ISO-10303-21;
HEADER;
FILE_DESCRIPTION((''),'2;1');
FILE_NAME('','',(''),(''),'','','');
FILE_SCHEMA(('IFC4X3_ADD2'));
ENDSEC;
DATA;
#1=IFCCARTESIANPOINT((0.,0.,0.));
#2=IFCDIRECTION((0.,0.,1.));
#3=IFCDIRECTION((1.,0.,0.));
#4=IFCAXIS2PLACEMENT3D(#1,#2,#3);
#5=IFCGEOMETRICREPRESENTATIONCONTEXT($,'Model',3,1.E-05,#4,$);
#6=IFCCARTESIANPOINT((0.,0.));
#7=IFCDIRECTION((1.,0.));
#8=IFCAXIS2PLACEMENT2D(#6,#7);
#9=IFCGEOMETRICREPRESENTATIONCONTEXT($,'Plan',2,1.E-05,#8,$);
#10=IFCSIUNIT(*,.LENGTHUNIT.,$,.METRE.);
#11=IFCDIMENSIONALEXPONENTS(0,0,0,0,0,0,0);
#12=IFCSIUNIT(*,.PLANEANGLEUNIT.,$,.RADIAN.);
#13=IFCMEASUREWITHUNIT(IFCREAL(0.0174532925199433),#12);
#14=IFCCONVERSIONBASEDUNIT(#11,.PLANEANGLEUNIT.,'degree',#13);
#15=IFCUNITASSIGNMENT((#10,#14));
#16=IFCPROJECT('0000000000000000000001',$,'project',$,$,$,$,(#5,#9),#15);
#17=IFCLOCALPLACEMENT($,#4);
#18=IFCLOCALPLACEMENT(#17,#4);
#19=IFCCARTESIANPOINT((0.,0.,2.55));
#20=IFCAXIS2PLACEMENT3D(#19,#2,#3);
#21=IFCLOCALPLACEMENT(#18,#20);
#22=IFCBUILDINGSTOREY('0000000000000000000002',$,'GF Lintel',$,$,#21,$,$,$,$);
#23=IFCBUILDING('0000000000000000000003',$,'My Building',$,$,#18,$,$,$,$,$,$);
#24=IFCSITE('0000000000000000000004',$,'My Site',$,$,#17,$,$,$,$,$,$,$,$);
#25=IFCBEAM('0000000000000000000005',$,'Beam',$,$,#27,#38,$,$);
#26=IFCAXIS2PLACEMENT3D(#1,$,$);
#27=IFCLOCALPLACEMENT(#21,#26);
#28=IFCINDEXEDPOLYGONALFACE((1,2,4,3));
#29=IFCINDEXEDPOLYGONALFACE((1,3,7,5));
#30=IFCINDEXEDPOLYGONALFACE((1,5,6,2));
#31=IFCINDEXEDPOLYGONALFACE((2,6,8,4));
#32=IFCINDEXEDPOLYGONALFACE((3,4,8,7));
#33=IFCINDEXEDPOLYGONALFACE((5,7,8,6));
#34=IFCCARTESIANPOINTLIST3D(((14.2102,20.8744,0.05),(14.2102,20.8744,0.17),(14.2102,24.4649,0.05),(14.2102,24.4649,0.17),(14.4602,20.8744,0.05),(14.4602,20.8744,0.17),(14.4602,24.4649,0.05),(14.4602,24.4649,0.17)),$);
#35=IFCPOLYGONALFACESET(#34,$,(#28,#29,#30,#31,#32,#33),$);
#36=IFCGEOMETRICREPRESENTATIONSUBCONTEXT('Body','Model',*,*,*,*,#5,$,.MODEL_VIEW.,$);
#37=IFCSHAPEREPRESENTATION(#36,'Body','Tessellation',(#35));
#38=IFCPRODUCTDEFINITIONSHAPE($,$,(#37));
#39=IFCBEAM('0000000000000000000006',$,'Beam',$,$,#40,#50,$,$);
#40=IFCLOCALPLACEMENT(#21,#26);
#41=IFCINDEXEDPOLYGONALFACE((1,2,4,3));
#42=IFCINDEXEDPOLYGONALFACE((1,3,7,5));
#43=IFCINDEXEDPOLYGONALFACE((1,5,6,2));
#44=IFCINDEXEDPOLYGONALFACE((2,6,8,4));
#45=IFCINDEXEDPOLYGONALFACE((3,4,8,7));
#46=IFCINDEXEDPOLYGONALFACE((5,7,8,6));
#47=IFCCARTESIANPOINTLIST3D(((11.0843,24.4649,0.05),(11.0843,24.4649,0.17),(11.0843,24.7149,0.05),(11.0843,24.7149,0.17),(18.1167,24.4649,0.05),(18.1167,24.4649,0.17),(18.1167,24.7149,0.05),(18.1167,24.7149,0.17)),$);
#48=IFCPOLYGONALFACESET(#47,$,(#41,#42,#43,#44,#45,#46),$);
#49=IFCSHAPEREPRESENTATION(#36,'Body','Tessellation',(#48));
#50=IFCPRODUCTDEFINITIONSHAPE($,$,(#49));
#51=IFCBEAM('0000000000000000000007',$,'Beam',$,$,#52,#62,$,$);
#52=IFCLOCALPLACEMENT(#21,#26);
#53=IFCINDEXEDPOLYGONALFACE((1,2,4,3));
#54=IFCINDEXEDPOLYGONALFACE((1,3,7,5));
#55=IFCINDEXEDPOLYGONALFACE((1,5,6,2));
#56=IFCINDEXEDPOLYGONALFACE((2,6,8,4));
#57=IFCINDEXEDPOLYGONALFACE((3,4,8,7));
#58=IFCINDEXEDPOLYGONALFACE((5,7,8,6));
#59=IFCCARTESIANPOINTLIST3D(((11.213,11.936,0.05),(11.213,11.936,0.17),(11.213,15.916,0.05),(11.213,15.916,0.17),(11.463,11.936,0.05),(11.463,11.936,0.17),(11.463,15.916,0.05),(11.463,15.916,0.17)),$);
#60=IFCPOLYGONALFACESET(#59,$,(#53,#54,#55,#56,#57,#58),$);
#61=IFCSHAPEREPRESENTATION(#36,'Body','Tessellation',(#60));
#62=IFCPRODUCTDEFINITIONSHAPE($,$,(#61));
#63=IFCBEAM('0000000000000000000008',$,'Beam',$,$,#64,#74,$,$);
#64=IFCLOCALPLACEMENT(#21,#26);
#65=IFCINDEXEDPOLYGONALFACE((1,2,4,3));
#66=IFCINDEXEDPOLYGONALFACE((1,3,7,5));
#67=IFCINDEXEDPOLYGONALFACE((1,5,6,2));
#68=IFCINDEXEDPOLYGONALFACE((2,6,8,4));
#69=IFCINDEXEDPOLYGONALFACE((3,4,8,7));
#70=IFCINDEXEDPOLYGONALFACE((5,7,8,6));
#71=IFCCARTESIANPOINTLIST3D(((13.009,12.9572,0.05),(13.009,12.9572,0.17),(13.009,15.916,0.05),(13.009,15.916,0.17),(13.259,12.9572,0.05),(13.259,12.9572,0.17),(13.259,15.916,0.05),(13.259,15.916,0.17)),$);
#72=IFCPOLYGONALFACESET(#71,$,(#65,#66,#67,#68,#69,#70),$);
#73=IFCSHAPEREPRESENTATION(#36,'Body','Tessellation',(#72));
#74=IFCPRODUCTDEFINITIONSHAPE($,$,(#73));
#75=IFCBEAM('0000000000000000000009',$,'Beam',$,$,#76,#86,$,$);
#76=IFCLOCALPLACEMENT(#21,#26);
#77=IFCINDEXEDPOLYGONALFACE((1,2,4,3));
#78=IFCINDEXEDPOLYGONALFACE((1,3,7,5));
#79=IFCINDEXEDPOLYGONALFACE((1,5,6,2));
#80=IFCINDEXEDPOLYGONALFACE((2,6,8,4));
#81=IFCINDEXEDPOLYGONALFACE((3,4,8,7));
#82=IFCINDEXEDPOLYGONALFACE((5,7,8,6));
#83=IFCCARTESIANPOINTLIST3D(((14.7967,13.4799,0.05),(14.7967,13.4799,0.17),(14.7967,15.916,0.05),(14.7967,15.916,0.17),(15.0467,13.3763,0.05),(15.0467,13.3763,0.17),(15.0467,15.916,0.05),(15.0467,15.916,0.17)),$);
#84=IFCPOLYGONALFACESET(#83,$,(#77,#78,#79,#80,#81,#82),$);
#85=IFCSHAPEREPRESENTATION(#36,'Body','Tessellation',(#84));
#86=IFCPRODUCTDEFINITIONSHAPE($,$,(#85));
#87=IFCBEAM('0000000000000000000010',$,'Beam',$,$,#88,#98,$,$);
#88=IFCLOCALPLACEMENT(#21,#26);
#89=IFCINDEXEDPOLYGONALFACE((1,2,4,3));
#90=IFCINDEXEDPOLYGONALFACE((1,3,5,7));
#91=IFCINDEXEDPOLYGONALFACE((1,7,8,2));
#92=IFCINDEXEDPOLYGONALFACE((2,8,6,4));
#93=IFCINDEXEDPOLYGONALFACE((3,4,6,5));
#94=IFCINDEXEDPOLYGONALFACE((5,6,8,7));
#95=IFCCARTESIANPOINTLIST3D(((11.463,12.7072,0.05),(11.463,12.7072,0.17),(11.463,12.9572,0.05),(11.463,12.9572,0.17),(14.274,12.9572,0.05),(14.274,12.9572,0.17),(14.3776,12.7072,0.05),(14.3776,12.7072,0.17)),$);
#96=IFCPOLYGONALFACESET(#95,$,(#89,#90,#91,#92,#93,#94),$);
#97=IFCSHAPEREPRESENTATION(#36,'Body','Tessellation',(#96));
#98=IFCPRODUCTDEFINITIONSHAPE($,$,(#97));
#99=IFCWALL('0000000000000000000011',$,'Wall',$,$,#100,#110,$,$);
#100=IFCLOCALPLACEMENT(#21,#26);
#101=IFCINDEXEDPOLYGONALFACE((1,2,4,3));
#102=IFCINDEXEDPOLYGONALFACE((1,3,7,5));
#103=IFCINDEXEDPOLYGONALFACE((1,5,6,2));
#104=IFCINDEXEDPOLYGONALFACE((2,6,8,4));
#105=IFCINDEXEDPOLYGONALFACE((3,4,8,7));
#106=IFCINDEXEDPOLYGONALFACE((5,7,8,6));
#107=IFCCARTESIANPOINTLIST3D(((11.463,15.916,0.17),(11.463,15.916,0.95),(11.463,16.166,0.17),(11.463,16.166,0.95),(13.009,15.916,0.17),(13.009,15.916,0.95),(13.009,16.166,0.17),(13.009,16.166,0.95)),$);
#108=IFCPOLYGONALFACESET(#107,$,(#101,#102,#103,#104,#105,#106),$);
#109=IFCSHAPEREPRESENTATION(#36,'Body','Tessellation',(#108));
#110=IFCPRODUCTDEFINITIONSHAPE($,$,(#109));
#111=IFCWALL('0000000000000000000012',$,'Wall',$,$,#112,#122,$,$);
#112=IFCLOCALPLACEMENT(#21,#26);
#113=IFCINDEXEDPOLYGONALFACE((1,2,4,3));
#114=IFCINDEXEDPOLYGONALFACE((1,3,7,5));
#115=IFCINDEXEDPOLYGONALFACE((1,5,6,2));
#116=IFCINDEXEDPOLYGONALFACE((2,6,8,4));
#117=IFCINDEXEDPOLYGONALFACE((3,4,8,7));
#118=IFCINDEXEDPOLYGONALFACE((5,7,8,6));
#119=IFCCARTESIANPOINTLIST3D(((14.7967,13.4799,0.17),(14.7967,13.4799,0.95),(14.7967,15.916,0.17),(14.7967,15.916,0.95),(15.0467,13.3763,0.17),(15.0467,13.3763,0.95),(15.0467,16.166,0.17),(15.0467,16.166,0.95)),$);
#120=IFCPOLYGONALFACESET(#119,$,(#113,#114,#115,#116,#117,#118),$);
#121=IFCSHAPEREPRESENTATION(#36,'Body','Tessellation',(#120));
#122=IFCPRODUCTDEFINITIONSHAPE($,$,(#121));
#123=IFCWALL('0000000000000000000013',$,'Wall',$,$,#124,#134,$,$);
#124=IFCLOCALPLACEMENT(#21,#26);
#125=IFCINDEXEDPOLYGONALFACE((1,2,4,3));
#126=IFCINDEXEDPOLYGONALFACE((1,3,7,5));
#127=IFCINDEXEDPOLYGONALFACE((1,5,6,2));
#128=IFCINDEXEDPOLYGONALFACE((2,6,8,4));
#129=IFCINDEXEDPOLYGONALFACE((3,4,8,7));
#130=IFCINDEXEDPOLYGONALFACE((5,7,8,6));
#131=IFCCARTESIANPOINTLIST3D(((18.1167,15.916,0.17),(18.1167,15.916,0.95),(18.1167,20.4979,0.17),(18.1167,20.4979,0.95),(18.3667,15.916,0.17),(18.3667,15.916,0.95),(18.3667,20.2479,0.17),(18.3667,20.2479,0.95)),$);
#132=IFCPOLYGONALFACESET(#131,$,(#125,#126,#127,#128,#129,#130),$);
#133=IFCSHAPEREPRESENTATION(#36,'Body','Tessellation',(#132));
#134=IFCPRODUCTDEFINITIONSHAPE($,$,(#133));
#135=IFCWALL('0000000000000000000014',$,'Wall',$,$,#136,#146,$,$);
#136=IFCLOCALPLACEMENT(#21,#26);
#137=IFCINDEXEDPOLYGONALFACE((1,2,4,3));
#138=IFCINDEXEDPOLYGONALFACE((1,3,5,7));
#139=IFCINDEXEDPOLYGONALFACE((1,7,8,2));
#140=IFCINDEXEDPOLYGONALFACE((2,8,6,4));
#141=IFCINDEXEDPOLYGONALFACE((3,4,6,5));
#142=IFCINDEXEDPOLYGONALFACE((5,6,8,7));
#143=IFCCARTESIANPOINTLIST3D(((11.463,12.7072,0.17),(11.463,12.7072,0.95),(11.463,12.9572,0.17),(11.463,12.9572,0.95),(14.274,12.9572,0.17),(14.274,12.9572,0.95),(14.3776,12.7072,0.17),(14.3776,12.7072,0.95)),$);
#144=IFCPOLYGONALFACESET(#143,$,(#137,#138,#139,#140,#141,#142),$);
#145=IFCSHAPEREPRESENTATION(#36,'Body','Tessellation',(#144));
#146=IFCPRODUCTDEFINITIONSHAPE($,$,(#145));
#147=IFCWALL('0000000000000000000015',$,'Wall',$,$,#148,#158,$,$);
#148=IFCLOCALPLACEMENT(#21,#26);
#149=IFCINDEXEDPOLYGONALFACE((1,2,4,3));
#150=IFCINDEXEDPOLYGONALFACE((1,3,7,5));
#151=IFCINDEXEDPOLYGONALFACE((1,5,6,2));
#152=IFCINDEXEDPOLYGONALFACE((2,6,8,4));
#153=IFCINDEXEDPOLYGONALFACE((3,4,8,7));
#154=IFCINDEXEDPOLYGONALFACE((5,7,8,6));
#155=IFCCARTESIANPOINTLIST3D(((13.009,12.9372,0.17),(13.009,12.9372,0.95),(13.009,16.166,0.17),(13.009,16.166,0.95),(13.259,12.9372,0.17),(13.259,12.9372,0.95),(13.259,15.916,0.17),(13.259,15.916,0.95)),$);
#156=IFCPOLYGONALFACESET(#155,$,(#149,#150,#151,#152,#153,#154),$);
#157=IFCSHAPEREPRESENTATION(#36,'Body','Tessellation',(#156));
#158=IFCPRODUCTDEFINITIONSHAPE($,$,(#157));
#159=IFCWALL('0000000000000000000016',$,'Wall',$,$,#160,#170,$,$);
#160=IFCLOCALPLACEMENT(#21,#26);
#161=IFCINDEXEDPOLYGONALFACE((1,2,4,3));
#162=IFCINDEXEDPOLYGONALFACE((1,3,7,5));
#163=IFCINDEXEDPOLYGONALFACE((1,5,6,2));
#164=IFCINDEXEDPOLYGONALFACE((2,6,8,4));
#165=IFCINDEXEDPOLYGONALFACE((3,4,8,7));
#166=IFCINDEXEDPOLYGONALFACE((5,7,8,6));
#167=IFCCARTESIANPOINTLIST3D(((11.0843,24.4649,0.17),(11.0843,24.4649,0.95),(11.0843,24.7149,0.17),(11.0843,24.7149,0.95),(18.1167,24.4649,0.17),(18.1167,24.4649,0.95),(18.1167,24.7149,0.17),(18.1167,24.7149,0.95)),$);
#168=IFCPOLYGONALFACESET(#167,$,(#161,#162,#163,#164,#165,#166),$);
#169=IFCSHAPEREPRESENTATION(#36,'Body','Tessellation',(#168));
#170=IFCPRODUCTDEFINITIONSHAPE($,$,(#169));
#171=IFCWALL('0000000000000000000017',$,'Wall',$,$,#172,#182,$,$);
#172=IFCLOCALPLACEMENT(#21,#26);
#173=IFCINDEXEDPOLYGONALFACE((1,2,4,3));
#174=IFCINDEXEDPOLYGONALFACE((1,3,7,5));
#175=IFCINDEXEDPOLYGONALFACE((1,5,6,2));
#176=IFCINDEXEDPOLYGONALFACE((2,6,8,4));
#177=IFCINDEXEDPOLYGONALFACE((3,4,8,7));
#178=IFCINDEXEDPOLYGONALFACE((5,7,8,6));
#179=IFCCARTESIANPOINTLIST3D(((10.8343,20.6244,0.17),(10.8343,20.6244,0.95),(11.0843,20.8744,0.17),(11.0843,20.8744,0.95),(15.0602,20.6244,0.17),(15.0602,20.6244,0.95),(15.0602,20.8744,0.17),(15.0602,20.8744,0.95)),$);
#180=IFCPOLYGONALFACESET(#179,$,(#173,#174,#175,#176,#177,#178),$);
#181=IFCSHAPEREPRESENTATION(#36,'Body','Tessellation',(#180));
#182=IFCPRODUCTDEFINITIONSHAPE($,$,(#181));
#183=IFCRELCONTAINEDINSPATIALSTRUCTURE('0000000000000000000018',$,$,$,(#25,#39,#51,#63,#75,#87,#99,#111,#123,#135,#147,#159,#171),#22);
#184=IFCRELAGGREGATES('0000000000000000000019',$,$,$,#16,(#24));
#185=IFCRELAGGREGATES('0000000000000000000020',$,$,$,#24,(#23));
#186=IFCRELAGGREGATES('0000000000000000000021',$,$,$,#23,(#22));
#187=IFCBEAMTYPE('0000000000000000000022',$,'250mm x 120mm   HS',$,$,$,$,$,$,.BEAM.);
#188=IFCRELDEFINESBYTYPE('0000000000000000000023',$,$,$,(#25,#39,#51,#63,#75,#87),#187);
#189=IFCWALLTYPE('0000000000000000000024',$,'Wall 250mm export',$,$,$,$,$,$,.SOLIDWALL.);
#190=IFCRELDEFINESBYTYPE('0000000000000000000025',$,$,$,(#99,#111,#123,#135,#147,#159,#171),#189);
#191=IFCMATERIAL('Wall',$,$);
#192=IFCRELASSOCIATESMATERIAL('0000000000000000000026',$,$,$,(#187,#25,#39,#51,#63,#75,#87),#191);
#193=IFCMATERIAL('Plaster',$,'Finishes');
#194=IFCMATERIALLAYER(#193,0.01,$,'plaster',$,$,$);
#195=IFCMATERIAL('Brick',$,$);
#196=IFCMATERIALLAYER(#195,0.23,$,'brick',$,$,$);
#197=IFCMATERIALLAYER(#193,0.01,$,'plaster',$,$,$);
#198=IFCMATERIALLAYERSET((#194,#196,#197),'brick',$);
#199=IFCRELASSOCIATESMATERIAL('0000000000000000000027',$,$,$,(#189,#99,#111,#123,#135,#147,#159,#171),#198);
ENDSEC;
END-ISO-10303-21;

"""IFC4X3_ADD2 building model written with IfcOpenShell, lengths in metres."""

from ifc_helpers import new_model, entity, si_unit, converted_unit, frame, origin_with_axes, origin_2d_with_axis, place, context, subcontext, project, spatial, line, indexed_curve, rectangle, outline, extrude, clip, halfspace, material, layer, layer_set, layer_usage, material_profile, profile_set, profile_usage, type_object, element, save


model = new_model("IFC4X3_ADD2")

# Units and contexts
model_context = context("Model", 3, precision=1e-05, world=origin_with_axes())
plan_context = context("Plan", 2, precision=1e-05, world=origin_2d_with_axis())
body_context = subcontext(model_context, "Body", "Model", "MODEL_VIEW")
ifc_project = project(units=[si_unit("LENGTHUNIT", "METRE"), converted_unit("PLANEANGLEUNIT", "degree", entity("IfcReal", 0.0174532925199433), si_unit("PLANEANGLEUNIT", "RADIAN"), dimensions=[0, 0, 0, 0, 0, 0, 0])], contexts=[model_context, plan_context])

# Site, building, storey
site_placement = place(None, origin_with_axes())
site = spatial("IfcSite", under=ifc_project, at=site_placement, Name="My Site")
building_placement = place(site_placement, origin_with_axes())
building = spatial("IfcBuilding", under=site, at=building_placement, Name="My Building")
storey_placement = place(building_placement, frame((0.0, 0.0, 2.55), z_axis=(0.0, 0.0, 1.0), x_axis=(1.0, 0.0, 0.0)))
storey = spatial("IfcBuildingStorey", under=building, at=storey_placement, Name="GF Lintel")

# Beams
ifc_material_1 = material(Name="Wall")
ifc_material_profile = material_profile(ifc_material_1, rectangle(XDim=0.25, YDim=0.12))
ifc_profile_set = profile_set([ifc_material_profile], Name="concrete")
ifc_profile_usage_1 = profile_usage(ifc_profile_set, cardinal=5)
beam_type = type_object("IfcBeamType", Name="250mm x 120mm   HS", PredefinedType="BEAM", material=ifc_profile_set)
beam_1_placement = place(storey_placement, frame((14.3352, 24.4649, 0.11), z_axis=(0.0, -1.0, 0.0), x_axis=(1.0, 0.0, 0.0)))
element("IfcBeam", 1, at=beam_1_placement, inside=storey, type_object=beam_type, material=ifc_profile_usage_1, Name="Beam", context=body_context, shape_type="SweptSolid", body=[
    extrude(rectangle(XDim=0.25, YDim=0.12), origin_with_axes(), (0.0, 0.0, 1.0), 3.5905),
])
ifc_profile_usage_2 = profile_usage(ifc_profile_set, cardinal=5)
beam_2_placement = place(storey_placement, frame((11.0843, 24.5899, 0.11), z_axis=(1.0, 0.0, 0.0), x_axis=(0.0, 1.0, 0.0)))
element("IfcBeam", 2, at=beam_2_placement, inside=storey, type_object=beam_type, material=ifc_profile_usage_2, Name="Beam", context=body_context, shape_type="SweptSolid", body=[
    extrude(rectangle(XDim=0.25, YDim=0.12), origin_with_axes(), (0.0, 0.0, 1.0), 7.0324),
])
ifc_profile_usage_3 = profile_usage(ifc_profile_set, cardinal=5)
beam_3_placement = place(storey_placement, frame((11.338, 15.916, 0.11), z_axis=(0.0, -1.0, 0.0), x_axis=(1.0, 0.0, 0.0)))
element("IfcBeam", 3, at=beam_3_placement, inside=storey, type_object=beam_type, material=ifc_profile_usage_3, Name="Beam", context=body_context, shape_type="SweptSolid", body=[
    extrude(rectangle(XDim=0.25, YDim=0.12), origin_with_axes(), (0.0, 0.0, 1.0), 3.98),
])
ifc_profile_usage_4 = profile_usage(ifc_profile_set, cardinal=5)
beam_4_placement = place(storey_placement, frame((13.134, 15.916, 0.11), z_axis=(0.0, -1.0, 0.0), x_axis=(1.0, 0.0, 0.0)))
element("IfcBeam", 4, at=beam_4_placement, inside=storey, type_object=beam_type, material=ifc_profile_usage_4, Name="Beam", context=body_context, shape_type="SweptSolid", body=[
    extrude(rectangle(XDim=0.25, YDim=0.12), origin_with_axes(), (0.0, 0.0, 1.0), 2.9588),
])
ifc_profile_usage_5 = profile_usage(ifc_profile_set, cardinal=5)
beam_5_placement = place(storey_placement, frame((14.9217, 15.916, 0.11), z_axis=(0.0, -1.0, 0.0), x_axis=(1.0, 0.0, 0.0)))
element("IfcBeam", 5, at=beam_5_placement, inside=storey, type_object=beam_type, material=ifc_profile_usage_5, Name="Beam", context=body_context, shape_type="Clipping", body=[
    clip(extrude(rectangle(XDim=0.25, YDim=0.12), origin_with_axes(), (0.0, 0.0, 1.0), 2.9147), halfspace(frame((0.125, -2.66, 2.5397), z_axis=(-0.382688, 0.0, 0.923878), x_axis=(0.0, 1.0, 0.0)), False)),
])
ifc_profile_usage_6 = profile_usage(ifc_profile_set, cardinal=5)
beam_6_placement = place(storey_placement, frame((11.463, 12.8322, 0.11), z_axis=(1.0, 0.0, 0.0), x_axis=(0.0, 1.0, 0.0)))
element("IfcBeam", 6, at=beam_6_placement, inside=storey, type_object=beam_type, material=ifc_profile_usage_6, Name="Beam", context=body_context, shape_type="Clipping", body=[
    clip(extrude(rectangle(XDim=0.25, YDim=0.12), origin_with_axes(), (0.0, 0.0, 1.0), 3.2896), halfspace(frame((-0.125, -2.66, 2.9146), z_axis=(0.382685, 0.0, 0.923879), x_axis=(0.0, -1.0, 0.0)), False)),
])

# Walls
ifc_material_2 = material(Name="Plaster", Category="Finishes")
ifc_layer_1 = layer(ifc_material_2, 0.01, Name="plaster")
ifc_material_3 = material(Name="Brick")
ifc_layer_2 = layer(ifc_material_3, 0.23, Name="brick")
ifc_layer_3 = layer(ifc_material_2, 0.01, Name="plaster")
ifc_layer_set = layer_set([ifc_layer_1, ifc_layer_2, ifc_layer_3], Name="brick")
ifc_layer_usage_1 = layer_usage(ifc_layer_set, "AXIS2", "POSITIVE", 0.0)
wall_type = type_object("IfcWallType", Name="Wall 250mm export", PredefinedType="SOLIDWALL", material=ifc_layer_set)
wall_1_placement = place(storey_placement, frame((11.463, 15.916, 0.17), z_axis=(0.0, 0.0, 1.0), x_axis=(1.0, 0.0, 0.0)))
element("IfcWall", 7, at=wall_1_placement, inside=storey, type_object=wall_type, material=ifc_layer_usage_1, Name="Wall", context=body_context, shape_type="SweptSolid", body=[
    extrude(outline(indexed_curve([(0.0, 0.0), (0.0, 0.25), (1.546, 0.25), (1.546, 0.0)], segments=[line(1, 2, 3, 4, 1)])), origin_with_axes(), (0.0, 0.0, 1.0), 0.78),
])
ifc_layer_usage_2 = layer_usage(ifc_layer_set, "AXIS2", "POSITIVE", 0.0)
wall_2_placement = place(storey_placement, frame((15.0467, 13.3763, 0.17), z_axis=(0.0, 0.0, 1.0), x_axis=(0.0, 1.0, 0.0)))
element("IfcWall", 8, at=wall_2_placement, inside=storey, type_object=wall_type, material=ifc_layer_usage_2, Name="Wall", context=body_context, shape_type="SweptSolid", body=[
    extrude(outline(indexed_curve([(0.0, 0.0), (0.1036, 0.25), (2.5397, 0.25), (2.7897, 0.0)], segments=[line(1, 2, 3, 4, 1)])), origin_with_axes(), (0.0, 0.0, 1.0), 0.78),
])
ifc_layer_usage_3 = layer_usage(ifc_layer_set, "AXIS2", "NEGATIVE", 0.0)
wall_3_placement = place(storey_placement, frame((18.1167, 15.916, 0.17), z_axis=(0.0, 0.0, 1.0), x_axis=(0.0, 1.0, 0.0)))
element("IfcWall", 9, at=wall_3_placement, inside=storey, type_object=wall_type, material=ifc_layer_usage_3, Name="Wall", context=body_context, shape_type="SweptSolid", body=[
    extrude(outline(indexed_curve([(0.0, -0.25), (0.0, 0.0), (4.5819, 0.0), (4.3319, -0.25)], segments=[line(1, 2, 3, 4, 1)])), origin_with_axes(), (0.0, 0.0, 1.0), 0.78),
])
ifc_layer_usage_4 = layer_usage(ifc_layer_set, "AXIS2", "POSITIVE", 0.0)
wall_4_placement = place(storey_placement, frame((11.463, 12.7072, 0.17), z_axis=(0.0, 0.0, 1.0), x_axis=(1.0, 0.0, 0.0)))
element("IfcWall", 10, at=wall_4_placement, inside=storey, type_object=wall_type, material=ifc_layer_usage_4, Name="Wall", context=body_context, shape_type="SweptSolid", body=[
    extrude(outline(indexed_curve([(0.0, 0.0), (0.0, 0.25), (2.811, 0.25), (2.9146, 0.0)], segments=[line(1, 2, 3, 4, 1)])), origin_with_axes(), (0.0, 0.0, 1.0), 0.78),
])
ifc_layer_usage_5 = layer_usage(ifc_layer_set, "AXIS2", "POSITIVE", 0.0)
wall_5_placement = place(storey_placement, frame((13.259, 12.9372, 0.17), z_axis=(0.0, 0.0, 1.0), x_axis=(0.0, 1.0, 0.0)))
element("IfcWall", 11, at=wall_5_placement, inside=storey, type_object=wall_type, material=ifc_layer_usage_5, Name="Wall", context=body_context, shape_type="SweptSolid", body=[
    extrude(outline(indexed_curve([(0.0, 0.0), (0.0, 0.25), (3.2288, 0.25), (2.9788, 0.0)], segments=[line(1, 2, 3, 4, 1)])), origin_with_axes(), (0.0, 0.0, 1.0), 0.78),
])
ifc_layer_usage_6 = layer_usage(ifc_layer_set, "AXIS2", "POSITIVE", 0.0)
wall_6_placement = place(storey_placement, frame((11.0843, 24.4649, 0.17), z_axis=(0.0, 0.0, 1.0), x_axis=(1.0, 0.0, 0.0)))
element("IfcWall", 12, at=wall_6_placement, inside=storey, type_object=wall_type, material=ifc_layer_usage_6, Name="Wall", context=body_context, shape_type="SweptSolid", body=[
    extrude(outline(indexed_curve([(0.0, 0.0), (0.0, 0.25), (7.0324, 0.25), (7.0324, 0.0)], segments=[line(1, 2, 3, 4, 1)])), origin_with_axes(), (0.0, 0.0, 1.0), 0.78),
])
ifc_layer_usage_7 = layer_usage(ifc_layer_set, "AXIS2", "POSITIVE", 0.0)
wall_7_placement = place(storey_placement, frame((11.0843, 20.6244, 0.17), z_axis=(0.0, 0.0, 1.0), x_axis=(1.0, 0.0, 0.0)))
element("IfcWall", 13, at=wall_7_placement, inside=storey, type_object=wall_type, material=ifc_layer_usage_7, Name="Wall", context=body_context, shape_type="SweptSolid", body=[
    extrude(outline(indexed_curve([(-0.25, 0.0), (0.0, 0.25), (3.9759, 0.25), (3.9759, 0.0)], segments=[line(1, 2, 3, 4, 1)])), origin_with_axes(), (0.0, 0.0, 1.0), 0.78),
])

save(model, "model.ifc")
